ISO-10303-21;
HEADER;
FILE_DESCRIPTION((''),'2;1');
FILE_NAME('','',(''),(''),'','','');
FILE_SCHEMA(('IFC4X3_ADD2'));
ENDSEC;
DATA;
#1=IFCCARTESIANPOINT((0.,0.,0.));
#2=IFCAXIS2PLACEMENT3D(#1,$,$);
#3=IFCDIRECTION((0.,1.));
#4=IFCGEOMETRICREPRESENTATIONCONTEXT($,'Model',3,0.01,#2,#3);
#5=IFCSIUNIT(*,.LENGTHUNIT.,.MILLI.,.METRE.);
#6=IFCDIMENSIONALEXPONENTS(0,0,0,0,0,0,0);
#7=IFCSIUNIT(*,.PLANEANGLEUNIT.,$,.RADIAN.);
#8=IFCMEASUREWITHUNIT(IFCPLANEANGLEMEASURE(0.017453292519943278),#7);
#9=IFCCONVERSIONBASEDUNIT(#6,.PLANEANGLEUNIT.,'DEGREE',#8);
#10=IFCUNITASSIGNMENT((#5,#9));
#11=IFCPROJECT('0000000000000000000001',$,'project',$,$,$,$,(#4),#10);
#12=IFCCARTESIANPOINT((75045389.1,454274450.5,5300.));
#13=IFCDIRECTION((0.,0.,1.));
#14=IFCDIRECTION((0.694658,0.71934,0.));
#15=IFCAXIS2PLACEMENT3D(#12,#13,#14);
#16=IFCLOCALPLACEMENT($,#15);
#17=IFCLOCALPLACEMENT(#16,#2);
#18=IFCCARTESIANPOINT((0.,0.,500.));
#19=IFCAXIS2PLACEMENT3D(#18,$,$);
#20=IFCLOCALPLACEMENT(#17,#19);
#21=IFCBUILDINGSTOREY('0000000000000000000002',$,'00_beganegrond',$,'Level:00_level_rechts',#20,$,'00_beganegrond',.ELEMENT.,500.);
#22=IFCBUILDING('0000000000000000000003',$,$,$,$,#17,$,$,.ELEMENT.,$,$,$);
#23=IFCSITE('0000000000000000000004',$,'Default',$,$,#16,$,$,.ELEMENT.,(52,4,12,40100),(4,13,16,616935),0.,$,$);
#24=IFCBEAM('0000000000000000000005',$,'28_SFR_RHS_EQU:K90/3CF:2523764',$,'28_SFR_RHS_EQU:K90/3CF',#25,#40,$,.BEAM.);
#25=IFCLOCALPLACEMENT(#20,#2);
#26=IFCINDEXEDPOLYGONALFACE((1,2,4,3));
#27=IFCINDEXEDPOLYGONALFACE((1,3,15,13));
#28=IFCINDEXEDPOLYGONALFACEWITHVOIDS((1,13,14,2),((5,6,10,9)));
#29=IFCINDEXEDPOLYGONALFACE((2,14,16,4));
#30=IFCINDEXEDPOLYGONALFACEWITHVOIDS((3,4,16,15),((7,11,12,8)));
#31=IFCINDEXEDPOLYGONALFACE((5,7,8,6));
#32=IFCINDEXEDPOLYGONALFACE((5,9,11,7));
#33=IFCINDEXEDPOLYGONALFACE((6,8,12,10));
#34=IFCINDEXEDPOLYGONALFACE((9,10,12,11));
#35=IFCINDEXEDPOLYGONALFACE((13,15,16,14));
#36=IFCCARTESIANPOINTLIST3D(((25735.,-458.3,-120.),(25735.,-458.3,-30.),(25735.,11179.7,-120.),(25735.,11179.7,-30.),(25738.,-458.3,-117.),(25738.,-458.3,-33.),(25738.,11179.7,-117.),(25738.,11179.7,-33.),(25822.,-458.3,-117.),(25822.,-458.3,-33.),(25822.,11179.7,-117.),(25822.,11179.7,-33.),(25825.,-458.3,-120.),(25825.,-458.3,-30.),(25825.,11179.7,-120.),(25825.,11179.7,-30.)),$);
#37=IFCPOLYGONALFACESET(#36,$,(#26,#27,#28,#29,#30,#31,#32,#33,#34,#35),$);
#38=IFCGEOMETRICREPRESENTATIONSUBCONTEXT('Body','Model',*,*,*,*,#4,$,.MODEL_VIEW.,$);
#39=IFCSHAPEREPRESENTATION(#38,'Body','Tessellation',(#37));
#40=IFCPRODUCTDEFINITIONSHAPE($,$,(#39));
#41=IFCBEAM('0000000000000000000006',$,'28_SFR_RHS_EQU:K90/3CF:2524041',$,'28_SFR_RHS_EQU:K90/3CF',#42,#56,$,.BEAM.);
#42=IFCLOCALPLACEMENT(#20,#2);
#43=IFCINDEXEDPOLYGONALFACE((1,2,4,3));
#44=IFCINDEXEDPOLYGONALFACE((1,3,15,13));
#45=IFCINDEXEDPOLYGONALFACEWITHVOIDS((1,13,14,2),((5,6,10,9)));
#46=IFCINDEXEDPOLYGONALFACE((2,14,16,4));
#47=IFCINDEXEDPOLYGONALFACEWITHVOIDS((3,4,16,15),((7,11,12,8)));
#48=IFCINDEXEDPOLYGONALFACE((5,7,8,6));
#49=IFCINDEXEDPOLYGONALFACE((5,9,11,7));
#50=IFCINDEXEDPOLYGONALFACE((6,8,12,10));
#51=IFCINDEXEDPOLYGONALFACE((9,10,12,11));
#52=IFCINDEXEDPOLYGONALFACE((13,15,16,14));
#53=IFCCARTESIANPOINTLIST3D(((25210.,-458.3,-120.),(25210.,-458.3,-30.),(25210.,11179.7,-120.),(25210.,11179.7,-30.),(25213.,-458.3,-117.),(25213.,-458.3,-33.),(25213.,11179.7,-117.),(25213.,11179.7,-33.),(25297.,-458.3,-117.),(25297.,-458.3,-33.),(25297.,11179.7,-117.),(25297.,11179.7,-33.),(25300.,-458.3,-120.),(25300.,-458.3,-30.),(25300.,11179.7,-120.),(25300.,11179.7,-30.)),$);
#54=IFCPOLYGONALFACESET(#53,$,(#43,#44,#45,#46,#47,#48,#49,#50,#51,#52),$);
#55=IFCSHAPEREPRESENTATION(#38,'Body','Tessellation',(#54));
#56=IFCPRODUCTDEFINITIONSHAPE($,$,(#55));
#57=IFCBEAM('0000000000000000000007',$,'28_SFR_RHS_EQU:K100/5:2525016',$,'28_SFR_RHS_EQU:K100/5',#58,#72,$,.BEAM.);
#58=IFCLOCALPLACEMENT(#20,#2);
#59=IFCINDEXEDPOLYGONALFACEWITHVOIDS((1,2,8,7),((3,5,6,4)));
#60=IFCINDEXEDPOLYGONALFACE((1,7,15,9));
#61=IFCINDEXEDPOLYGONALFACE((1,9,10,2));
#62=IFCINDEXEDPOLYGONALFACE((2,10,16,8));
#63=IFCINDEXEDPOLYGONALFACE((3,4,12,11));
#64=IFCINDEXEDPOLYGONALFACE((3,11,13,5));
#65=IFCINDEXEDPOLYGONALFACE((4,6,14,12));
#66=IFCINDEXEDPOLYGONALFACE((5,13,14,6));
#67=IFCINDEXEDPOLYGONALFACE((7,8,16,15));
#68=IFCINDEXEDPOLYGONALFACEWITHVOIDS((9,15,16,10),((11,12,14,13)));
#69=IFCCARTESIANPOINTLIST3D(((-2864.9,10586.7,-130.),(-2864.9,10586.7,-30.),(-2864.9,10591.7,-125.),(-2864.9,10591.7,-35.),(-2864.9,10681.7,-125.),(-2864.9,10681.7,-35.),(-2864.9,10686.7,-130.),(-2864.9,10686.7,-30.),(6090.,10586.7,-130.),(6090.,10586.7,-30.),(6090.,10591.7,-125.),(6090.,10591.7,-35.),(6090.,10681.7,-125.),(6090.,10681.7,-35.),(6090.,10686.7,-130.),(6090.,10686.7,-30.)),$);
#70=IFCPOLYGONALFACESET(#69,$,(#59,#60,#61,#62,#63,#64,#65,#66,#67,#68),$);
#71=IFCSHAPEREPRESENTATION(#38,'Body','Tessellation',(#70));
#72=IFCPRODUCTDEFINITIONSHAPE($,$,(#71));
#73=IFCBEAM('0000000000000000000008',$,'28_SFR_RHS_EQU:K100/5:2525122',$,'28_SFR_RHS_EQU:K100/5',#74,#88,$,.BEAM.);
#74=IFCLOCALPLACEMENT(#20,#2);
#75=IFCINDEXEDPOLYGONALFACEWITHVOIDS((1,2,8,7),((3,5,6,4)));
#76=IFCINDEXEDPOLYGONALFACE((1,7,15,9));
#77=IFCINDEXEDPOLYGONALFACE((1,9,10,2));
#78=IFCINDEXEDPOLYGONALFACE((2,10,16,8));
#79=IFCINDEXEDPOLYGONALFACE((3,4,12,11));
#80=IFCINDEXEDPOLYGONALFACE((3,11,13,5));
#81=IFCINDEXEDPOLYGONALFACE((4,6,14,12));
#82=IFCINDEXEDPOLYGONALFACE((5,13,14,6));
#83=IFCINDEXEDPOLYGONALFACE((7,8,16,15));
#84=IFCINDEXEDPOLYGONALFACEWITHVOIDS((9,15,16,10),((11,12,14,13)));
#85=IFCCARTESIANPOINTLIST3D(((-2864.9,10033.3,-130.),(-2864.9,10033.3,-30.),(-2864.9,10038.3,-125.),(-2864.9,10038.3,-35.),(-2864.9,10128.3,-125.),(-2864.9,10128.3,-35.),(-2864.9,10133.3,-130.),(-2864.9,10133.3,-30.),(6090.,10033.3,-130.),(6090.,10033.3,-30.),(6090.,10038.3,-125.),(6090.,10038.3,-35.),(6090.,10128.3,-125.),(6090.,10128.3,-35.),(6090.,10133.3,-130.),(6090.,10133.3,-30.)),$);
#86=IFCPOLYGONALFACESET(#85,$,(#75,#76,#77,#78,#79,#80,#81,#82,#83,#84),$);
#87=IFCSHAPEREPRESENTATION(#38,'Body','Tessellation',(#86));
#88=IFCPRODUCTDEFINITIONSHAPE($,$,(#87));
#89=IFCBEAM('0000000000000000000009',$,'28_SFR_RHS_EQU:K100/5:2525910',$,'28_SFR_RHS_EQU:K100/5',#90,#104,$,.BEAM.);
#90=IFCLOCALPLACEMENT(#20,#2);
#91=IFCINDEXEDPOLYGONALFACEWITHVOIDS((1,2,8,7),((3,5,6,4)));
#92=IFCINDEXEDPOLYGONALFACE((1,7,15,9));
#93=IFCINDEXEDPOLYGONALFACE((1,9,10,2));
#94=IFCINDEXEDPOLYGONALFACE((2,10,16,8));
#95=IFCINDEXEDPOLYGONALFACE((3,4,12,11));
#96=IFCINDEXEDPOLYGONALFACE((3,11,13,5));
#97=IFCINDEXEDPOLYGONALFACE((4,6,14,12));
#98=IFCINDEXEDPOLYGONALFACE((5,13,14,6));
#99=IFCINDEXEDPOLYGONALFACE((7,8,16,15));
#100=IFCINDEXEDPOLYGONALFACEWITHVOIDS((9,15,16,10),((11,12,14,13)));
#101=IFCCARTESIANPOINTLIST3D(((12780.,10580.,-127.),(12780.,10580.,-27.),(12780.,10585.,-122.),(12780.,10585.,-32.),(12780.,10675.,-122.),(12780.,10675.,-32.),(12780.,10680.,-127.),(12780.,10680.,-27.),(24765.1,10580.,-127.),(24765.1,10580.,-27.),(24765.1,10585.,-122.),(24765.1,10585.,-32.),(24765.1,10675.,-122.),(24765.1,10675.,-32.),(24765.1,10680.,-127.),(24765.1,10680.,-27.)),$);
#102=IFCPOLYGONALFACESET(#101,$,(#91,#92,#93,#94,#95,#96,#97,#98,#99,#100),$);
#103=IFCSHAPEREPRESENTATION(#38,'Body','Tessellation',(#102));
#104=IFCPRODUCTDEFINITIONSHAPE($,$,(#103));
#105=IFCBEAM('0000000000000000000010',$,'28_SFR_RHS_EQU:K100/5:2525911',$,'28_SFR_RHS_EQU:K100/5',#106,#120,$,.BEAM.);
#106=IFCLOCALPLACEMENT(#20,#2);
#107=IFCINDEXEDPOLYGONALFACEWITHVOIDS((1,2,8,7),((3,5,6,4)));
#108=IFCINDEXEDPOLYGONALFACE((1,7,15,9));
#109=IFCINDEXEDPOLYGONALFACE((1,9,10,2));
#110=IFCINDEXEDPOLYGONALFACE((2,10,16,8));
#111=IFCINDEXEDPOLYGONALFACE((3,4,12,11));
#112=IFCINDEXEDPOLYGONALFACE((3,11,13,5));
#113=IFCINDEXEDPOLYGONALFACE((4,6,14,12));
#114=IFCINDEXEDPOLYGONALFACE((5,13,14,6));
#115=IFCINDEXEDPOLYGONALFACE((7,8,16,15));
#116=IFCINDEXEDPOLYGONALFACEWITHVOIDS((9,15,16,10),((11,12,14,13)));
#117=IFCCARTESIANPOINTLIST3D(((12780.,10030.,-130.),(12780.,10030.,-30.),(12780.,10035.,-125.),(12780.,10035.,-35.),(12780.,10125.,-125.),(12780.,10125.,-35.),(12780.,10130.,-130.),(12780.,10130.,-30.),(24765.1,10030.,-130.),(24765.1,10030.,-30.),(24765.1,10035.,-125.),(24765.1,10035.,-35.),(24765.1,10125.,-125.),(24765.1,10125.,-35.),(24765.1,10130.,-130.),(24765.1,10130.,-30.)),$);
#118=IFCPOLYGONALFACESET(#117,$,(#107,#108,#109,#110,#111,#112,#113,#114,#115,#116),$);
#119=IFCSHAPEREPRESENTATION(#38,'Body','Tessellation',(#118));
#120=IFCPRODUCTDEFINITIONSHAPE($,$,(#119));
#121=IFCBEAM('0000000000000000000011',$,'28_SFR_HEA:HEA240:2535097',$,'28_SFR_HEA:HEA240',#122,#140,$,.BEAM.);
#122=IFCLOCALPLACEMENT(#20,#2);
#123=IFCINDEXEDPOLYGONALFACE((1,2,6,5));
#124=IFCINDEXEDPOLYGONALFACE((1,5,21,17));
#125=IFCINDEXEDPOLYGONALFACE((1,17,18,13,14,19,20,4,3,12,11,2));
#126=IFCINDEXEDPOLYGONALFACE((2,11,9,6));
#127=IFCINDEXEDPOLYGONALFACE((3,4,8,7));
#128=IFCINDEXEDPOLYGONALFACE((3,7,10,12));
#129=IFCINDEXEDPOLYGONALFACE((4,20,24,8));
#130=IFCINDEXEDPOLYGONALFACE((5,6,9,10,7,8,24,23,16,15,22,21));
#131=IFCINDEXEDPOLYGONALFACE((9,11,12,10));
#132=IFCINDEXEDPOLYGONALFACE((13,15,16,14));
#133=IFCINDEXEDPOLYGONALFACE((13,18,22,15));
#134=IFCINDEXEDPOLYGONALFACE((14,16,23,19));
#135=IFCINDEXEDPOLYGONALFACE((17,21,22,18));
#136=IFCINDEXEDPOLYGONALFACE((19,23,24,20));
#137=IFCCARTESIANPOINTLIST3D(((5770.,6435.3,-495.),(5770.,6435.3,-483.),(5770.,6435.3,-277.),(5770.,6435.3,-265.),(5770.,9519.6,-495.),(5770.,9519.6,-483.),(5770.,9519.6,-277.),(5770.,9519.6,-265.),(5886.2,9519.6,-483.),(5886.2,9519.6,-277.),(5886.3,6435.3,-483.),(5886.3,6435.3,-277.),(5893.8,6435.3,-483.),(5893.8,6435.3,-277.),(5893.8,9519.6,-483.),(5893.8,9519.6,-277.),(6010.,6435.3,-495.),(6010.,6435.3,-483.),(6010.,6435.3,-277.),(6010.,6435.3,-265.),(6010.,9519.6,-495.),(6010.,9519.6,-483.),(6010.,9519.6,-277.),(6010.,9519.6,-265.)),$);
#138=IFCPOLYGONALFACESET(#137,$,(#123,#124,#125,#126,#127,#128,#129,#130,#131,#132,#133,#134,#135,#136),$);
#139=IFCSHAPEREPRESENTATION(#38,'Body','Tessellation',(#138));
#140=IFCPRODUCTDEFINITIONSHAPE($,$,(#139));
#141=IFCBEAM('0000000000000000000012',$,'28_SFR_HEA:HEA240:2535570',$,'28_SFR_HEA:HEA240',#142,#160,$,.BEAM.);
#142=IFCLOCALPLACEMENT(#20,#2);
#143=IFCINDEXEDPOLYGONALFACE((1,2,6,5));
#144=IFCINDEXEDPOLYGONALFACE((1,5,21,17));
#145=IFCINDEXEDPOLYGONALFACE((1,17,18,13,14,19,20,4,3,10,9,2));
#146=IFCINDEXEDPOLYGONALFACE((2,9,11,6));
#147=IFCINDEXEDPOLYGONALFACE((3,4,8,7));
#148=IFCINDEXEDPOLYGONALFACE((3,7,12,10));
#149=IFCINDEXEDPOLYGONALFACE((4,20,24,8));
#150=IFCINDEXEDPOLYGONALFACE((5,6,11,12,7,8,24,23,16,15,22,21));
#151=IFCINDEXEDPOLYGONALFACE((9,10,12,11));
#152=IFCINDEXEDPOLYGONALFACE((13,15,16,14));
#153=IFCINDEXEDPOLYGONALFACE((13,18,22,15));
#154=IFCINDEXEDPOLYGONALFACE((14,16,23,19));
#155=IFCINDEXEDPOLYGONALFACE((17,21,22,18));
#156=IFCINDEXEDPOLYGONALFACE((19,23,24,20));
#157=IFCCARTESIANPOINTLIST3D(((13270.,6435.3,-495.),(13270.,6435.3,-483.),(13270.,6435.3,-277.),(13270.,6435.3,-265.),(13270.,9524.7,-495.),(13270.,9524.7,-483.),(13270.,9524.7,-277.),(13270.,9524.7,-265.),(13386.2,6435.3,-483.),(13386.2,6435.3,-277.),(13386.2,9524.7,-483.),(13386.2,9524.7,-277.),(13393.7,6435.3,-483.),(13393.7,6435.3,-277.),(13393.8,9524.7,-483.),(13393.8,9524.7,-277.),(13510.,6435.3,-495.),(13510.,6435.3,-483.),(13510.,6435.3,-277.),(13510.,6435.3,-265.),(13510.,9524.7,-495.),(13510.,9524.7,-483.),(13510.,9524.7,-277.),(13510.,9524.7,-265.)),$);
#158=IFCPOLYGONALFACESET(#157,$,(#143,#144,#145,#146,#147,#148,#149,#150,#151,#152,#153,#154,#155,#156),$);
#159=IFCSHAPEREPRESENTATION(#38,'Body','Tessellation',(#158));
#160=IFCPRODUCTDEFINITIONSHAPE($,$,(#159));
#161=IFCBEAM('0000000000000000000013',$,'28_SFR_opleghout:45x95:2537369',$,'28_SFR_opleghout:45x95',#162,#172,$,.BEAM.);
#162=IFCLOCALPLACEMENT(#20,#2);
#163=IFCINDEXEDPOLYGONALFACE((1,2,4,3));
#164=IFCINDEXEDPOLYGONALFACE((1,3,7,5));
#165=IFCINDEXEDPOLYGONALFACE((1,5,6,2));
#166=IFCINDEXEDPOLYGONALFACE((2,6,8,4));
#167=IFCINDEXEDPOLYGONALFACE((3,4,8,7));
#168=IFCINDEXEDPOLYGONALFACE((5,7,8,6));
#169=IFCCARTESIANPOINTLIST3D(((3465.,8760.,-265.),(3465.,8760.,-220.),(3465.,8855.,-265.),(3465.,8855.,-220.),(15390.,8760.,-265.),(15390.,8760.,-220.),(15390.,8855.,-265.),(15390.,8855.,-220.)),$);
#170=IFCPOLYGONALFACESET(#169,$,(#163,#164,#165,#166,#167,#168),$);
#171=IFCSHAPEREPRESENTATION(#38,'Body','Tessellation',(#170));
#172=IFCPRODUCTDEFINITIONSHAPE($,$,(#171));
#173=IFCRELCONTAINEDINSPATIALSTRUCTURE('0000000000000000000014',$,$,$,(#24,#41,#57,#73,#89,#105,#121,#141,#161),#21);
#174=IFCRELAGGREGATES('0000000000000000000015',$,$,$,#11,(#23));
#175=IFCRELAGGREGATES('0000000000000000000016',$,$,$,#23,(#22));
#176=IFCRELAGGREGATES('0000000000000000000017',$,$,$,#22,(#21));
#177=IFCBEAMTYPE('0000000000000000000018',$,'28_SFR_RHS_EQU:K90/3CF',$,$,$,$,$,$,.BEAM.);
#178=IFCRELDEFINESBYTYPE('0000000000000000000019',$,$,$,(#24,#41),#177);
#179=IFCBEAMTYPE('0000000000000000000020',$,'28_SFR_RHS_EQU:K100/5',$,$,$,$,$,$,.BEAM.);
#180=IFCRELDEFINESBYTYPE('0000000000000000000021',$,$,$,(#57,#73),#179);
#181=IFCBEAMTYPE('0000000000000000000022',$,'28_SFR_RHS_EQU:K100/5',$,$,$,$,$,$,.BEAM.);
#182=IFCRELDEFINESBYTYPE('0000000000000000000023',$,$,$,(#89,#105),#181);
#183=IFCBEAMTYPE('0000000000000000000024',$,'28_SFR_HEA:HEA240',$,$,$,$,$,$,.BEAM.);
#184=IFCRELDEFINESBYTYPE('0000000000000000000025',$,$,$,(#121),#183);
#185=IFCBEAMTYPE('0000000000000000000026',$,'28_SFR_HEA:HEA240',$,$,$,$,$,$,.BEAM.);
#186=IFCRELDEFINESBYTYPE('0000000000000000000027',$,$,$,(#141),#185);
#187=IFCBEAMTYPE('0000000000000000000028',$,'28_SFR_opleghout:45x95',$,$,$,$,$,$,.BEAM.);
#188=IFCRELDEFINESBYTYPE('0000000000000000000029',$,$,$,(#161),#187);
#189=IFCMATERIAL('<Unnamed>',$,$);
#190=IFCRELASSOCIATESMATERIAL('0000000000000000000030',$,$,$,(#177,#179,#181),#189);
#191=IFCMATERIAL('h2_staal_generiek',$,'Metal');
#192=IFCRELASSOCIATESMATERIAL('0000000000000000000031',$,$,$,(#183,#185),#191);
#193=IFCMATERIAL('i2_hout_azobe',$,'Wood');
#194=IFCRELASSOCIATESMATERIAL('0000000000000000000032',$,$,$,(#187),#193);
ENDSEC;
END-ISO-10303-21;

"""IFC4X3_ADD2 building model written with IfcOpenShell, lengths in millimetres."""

from ifc_helpers import new_model, entity, si_unit, converted_unit, direction, frame, frame_2d, origin, place, context, subcontext, project, spatial, polyline, rectangle, outline, extrude, source, transform, mapped, material, material_profile, profile_set, type_object, type_shapes, element, save


model = new_model("IFC4X3_ADD2")

# Units and contexts
model_context = context("Model", 3, precision=0.01, world=origin(), true_north=direction((0.0, 1.0)))
body_context = subcontext(model_context, "Body", "Model", "MODEL_VIEW")
ifc_project = project(units=[si_unit("LENGTHUNIT", "METRE", prefix="MILLI"), converted_unit("PLANEANGLEUNIT", "DEGREE", entity("IfcPlaneAngleMeasure", 0.017453292519943278), si_unit("PLANEANGLEUNIT", "RADIAN"), dimensions=[0, 0, 0, 0, 0, 0, 0])], contexts=[model_context])

# Site, building, storey
site_placement = place(None, frame((75045389.1, 454274450.5, 5300.0), z_axis=(0.0, 0.0, 1.0), x_axis=(0.694658, 0.71934, 0.0)))
site = spatial("IfcSite", under=ifc_project, at=site_placement, Name="Default", CompositionType="ELEMENT", RefLatitude=(52, 4, 12, 40100), RefLongitude=(4, 13, 16, 616935), RefElevation=0.0)
building_placement = place(site_placement, origin())
building = spatial("IfcBuilding", under=site, at=building_placement, CompositionType="ELEMENT")
storey_placement = place(building_placement, frame((0.0, 0.0, 500.0)))
storey = spatial("IfcBuildingStorey", under=building, at=storey_placement, Name="00_beganegrond", ObjectType="Level:00_level_rechts", LongName="00_beganegrond", CompositionType="ELEMENT", Elevation=500.0)

# Beams
ifc_material_1 = material(Name="<Unnamed>")
ifc_material_profile_1 = material_profile(ifc_material_1, outline(polyline([(-45.0, -45.0), (45.0, -45.0), (45.0, 45.0), (-45.0, 45.0), (-45.0, -45.0)]), holes=[polyline([(42.0, -42.0), (-42.0, -42.0), (-42.0, 42.0), (42.0, 42.0), (42.0, -42.0)])]), Name="K90/3CF")
ifc_profile_set_1 = profile_set([ifc_material_profile_1], Name="K90/3CF")
beam_type_1 = type_object("IfcBeamType", Name="28_SFR_RHS_EQU:K90/3CF", PredefinedType="BEAM", material=ifc_profile_set_1)
shared_shape_1 = source(origin(), body_context, "Body", "SweptSolid", [
    extrude(outline(polyline([(-45.0, -45.0), (45.0, -45.0), (45.0, 45.0), (-45.0, 45.0), (-45.0, -45.0)]), holes=[polyline([(42.0, -42.0), (-42.0, -42.0), (-42.0, 42.0), (42.0, 42.0), (42.0, -42.0)])]), frame((-5819.0, 0.0, 0.0), z_axis=(1.0, 0.0, 0.0), x_axis=(0.0, -1.0, 0.0)), (0.0, 0.0, 1.0), 11638.0),
])
type_shapes(beam_type_1, [shared_shape_1])
for number, where, z_axis, x_axis, name in (
    (1, (25780.0, 5360.7, -75.0), (0.0, 0.0, 1.0), (0.0, 1.0, 0.0), "28_SFR_RHS_EQU:K90/3CF:2523764"),
    (2, (25255.0, 5360.7, -75.0), (0.0, 0.0, 1.0), (0.0, 1.0, 0.0), "28_SFR_RHS_EQU:K90/3CF:2524041"),
):
    element("IfcBeam", number, at=place(storey_placement, frame(where, z_axis=z_axis, x_axis=x_axis)), inside=storey, type_object=beam_type_1, Name=name, ObjectType="28_SFR_RHS_EQU:K90/3CF", PredefinedType="BEAM", context=body_context, shape_type="MappedRepresentation", body=[
        mapped(shared_shape_1, transform((0.0, 0.0, 0.0), scale=1.0)),
    ])
ifc_material_profile_2 = material_profile(ifc_material_1, outline(polyline([(-50.0, -50.0), (50.0, -50.0), (50.0, 50.0), (-50.0, 50.0), (-50.0, -50.0)]), holes=[polyline([(45.0, -45.0), (-45.0, -45.0), (-45.0, 45.0), (45.0, 45.0), (45.0, -45.0)])]), Name="K100/5")
ifc_profile_set_2 = profile_set([ifc_material_profile_2], Name="K100/5")
beam_type_2 = type_object("IfcBeamType", Name="28_SFR_RHS_EQU:K100/5", PredefinedType="BEAM", material=ifc_profile_set_2)
shared_shape_2 = source(origin(), body_context, "Body", "SweptSolid", [
    extrude(outline(polyline([(-50.0, -50.0), (50.0, -50.0), (50.0, 50.0), (-50.0, 50.0), (-50.0, -50.0)]), holes=[polyline([(45.0, -45.0), (-45.0, -45.0), (-45.0, 45.0), (45.0, 45.0), (45.0, -45.0)])]), frame((-3822.4, 0.0, 0.0), z_axis=(1.0, 0.0, 0.0), x_axis=(0.0, -1.0, 0.0)), (0.0, 0.0, 1.0), 8954.9),
])
type_shapes(beam_type_2, [shared_shape_2])
for number, where, name in (
    (3, (957.5, 10636.7, -80.0), "28_SFR_RHS_EQU:K100/5:2525016"),
    (4, (957.5, 10083.3, -80.0), "28_SFR_RHS_EQU:K100/5:2525122"),
):
    element("IfcBeam", number, at=place(storey_placement, frame(where)), inside=storey, type_object=beam_type_2, Name=name, ObjectType="28_SFR_RHS_EQU:K100/5", PredefinedType="BEAM", context=body_context, shape_type="MappedRepresentation", body=[
        mapped(shared_shape_2, transform((0.0, 0.0, 0.0), scale=1.0)),
    ])
beam_type_3 = type_object("IfcBeamType", Name="28_SFR_RHS_EQU:K100/5", PredefinedType="BEAM", material=ifc_profile_set_2)
shared_shape_3 = source(origin(), body_context, "Body", "SweptSolid", [
    extrude(outline(polyline([(-50.0, -50.0), (50.0, -50.0), (50.0, 50.0), (-50.0, 50.0), (-50.0, -50.0)]), holes=[polyline([(45.0, -45.0), (-45.0, -45.0), (-45.0, 45.0), (45.0, 45.0), (45.0, -45.0)])]), frame((-6757.5, 0.0, 0.0), z_axis=(1.0, 0.0, 0.0), x_axis=(0.0, -1.0, 0.0)), (0.0, 0.0, 1.0), 11985.1),
])
type_shapes(beam_type_3, [shared_shape_3])
for number, where, name in (
    (5, (19537.5, 10630.0, -77.0), "28_SFR_RHS_EQU:K100/5:2525910"),
    (6, (19537.5, 10080.0, -80.0), "28_SFR_RHS_EQU:K100/5:2525911"),
):
    element("IfcBeam", number, at=place(storey_placement, frame(where)), inside=storey, type_object=beam_type_3, Name=name, ObjectType="28_SFR_RHS_EQU:K100/5", PredefinedType="BEAM", context=body_context, shape_type="MappedRepresentation", body=[
        mapped(shared_shape_3, transform((0.0, 0.0, 0.0), scale=1.0)),
    ])
ifc_material_2 = material(Name="h2_staal_generiek", Category="Metal")
ifc_material_profile_3 = material_profile(ifc_material_2, outline(polyline([(-120.0, -103.0), (-120.0, -115.0), (120.0, -115.0), (120.0, -103.0), (3.7, -103.0), (3.7, 103.0), (120.0, 103.0), (120.0, 115.0), (-120.0, 115.0), (-120.0, 103.0), (-3.8, 103.0), (-3.8, -103.0), (-120.0, -103.0)])), Name="HEA240")
ifc_profile_set_3 = profile_set([ifc_material_profile_3], Name="HEA240")
beam_type_4 = type_object("IfcBeamType", Name="28_SFR_HEA:HEA240", PredefinedType="BEAM", material=ifc_profile_set_3)
shared_shape_4 = source(origin(), body_context, "Body", "SweptSolid", [
    extrude(outline(polyline([(-120.0, -103.0), (-120.0, -115.0), (120.0, -115.0), (120.0, -103.0), (3.7, -103.0), (3.7, 103.0), (120.0, 103.0), (120.0, 115.0), (-120.0, 115.0), (-120.0, 103.0), (-3.8, 103.0), (-3.8, -103.0), (-120.0, -103.0)])), frame((-1441.7, 0.0, 0.0), z_axis=(-1.0, 0.0, 0.0), x_axis=(0.0, -1.0, 0.0)), (0.0, 0.0, -1.0), 3084.4),
])
type_shapes(beam_type_4, [shared_shape_4])
beam_1_placement = place(storey_placement, frame((5890.0, 8077.9, -380.0), z_axis=(0.0, 0.0, 1.0), x_axis=(0.0, -1.0, 0.0)))
element("IfcBeam", 7, at=beam_1_placement, inside=storey, type_object=beam_type_4, Name="28_SFR_HEA:HEA240:2535097", ObjectType="28_SFR_HEA:HEA240", PredefinedType="BEAM", context=body_context, shape_type="MappedRepresentation", body=[
    mapped(shared_shape_4, transform((0.0, 0.0, 0.0), scale=1.0)),
])
beam_type_5 = type_object("IfcBeamType", Name="28_SFR_HEA:HEA240", PredefinedType="BEAM", material=ifc_profile_set_3)
shared_shape_5 = source(origin(), body_context, "Body", "SweptSolid", [
    extrude(outline(polyline([(-120.0, -103.0), (-120.0, -115.0), (120.0, -115.0), (120.0, -103.0), (3.7, -103.0), (3.7, 103.0), (120.0, 103.0), (120.0, 115.0), (-120.0, 115.0), (-120.0, 103.0), (-3.8, 103.0), (-3.8, -103.0), (-120.0, -103.0)])), frame((-1489.5, 0.0, 0.0), z_axis=(-1.0, 0.0, 0.0), x_axis=(0.0, -1.0, 0.0)), (0.0, 0.0, -1.0), 3089.4),
])
type_shapes(beam_type_5, [shared_shape_5])
beam_2_placement = place(storey_placement, frame((13390.0, 8035.2, -380.0), z_axis=(0.0, 0.0, 1.0), x_axis=(0.0, -1.0, 0.0)))
element("IfcBeam", 8, at=beam_2_placement, inside=storey, type_object=beam_type_5, Name="28_SFR_HEA:HEA240:2535570", ObjectType="28_SFR_HEA:HEA240", PredefinedType="BEAM", context=body_context, shape_type="MappedRepresentation", body=[
    mapped(shared_shape_5, transform((0.0, 0.0, 0.0), scale=1.0)),
])
ifc_material_3 = material(Name="i2_hout_azobe", Category="Wood")
ifc_material_profile_4 = material_profile(ifc_material_3, rectangle(XDim=11925.0, YDim=95.0, at=frame_2d((0.0, 0.0), x_axis=(1.0, 0.0))), Name="45x95")
ifc_profile_set_4 = profile_set([ifc_material_profile_4], Name="45x95")
beam_type_6 = type_object("IfcBeamType", Name="28_SFR_opleghout:45x95", PredefinedType="BEAM", material=ifc_profile_set_4)
shared_shape_6 = source(origin(), body_context, "Body", "SweptSolid", [
    extrude(rectangle(XDim=11925.0, YDim=95.0, at=frame_2d((0.0, 0.0), x_axis=(1.0, 0.0))), frame((5962.5, 47.5, 0.0), z_axis=(0.0, 0.0, 1.0), x_axis=(-1.0, 0.0, 0.0)), (0.0, 0.0, 1.0), 45.0),
])
type_shapes(beam_type_6, [shared_shape_6])
for number, where, name in (
    (9, (3465.0, 8760.0, -265.0), "28_SFR_opleghout:45x95:2537369"),
):
    element("IfcBeam", number, at=place(storey_placement, frame(where)), inside=storey, type_object=beam_type_6, Name=name, ObjectType="28_SFR_opleghout:45x95", PredefinedType="BEAM", context=body_context, shape_type="MappedRepresentation", body=[
        mapped(shared_shape_6, transform((0.0, 0.0, 0.0), scale=1.0)),
    ])

save(model, "model.ifc")
